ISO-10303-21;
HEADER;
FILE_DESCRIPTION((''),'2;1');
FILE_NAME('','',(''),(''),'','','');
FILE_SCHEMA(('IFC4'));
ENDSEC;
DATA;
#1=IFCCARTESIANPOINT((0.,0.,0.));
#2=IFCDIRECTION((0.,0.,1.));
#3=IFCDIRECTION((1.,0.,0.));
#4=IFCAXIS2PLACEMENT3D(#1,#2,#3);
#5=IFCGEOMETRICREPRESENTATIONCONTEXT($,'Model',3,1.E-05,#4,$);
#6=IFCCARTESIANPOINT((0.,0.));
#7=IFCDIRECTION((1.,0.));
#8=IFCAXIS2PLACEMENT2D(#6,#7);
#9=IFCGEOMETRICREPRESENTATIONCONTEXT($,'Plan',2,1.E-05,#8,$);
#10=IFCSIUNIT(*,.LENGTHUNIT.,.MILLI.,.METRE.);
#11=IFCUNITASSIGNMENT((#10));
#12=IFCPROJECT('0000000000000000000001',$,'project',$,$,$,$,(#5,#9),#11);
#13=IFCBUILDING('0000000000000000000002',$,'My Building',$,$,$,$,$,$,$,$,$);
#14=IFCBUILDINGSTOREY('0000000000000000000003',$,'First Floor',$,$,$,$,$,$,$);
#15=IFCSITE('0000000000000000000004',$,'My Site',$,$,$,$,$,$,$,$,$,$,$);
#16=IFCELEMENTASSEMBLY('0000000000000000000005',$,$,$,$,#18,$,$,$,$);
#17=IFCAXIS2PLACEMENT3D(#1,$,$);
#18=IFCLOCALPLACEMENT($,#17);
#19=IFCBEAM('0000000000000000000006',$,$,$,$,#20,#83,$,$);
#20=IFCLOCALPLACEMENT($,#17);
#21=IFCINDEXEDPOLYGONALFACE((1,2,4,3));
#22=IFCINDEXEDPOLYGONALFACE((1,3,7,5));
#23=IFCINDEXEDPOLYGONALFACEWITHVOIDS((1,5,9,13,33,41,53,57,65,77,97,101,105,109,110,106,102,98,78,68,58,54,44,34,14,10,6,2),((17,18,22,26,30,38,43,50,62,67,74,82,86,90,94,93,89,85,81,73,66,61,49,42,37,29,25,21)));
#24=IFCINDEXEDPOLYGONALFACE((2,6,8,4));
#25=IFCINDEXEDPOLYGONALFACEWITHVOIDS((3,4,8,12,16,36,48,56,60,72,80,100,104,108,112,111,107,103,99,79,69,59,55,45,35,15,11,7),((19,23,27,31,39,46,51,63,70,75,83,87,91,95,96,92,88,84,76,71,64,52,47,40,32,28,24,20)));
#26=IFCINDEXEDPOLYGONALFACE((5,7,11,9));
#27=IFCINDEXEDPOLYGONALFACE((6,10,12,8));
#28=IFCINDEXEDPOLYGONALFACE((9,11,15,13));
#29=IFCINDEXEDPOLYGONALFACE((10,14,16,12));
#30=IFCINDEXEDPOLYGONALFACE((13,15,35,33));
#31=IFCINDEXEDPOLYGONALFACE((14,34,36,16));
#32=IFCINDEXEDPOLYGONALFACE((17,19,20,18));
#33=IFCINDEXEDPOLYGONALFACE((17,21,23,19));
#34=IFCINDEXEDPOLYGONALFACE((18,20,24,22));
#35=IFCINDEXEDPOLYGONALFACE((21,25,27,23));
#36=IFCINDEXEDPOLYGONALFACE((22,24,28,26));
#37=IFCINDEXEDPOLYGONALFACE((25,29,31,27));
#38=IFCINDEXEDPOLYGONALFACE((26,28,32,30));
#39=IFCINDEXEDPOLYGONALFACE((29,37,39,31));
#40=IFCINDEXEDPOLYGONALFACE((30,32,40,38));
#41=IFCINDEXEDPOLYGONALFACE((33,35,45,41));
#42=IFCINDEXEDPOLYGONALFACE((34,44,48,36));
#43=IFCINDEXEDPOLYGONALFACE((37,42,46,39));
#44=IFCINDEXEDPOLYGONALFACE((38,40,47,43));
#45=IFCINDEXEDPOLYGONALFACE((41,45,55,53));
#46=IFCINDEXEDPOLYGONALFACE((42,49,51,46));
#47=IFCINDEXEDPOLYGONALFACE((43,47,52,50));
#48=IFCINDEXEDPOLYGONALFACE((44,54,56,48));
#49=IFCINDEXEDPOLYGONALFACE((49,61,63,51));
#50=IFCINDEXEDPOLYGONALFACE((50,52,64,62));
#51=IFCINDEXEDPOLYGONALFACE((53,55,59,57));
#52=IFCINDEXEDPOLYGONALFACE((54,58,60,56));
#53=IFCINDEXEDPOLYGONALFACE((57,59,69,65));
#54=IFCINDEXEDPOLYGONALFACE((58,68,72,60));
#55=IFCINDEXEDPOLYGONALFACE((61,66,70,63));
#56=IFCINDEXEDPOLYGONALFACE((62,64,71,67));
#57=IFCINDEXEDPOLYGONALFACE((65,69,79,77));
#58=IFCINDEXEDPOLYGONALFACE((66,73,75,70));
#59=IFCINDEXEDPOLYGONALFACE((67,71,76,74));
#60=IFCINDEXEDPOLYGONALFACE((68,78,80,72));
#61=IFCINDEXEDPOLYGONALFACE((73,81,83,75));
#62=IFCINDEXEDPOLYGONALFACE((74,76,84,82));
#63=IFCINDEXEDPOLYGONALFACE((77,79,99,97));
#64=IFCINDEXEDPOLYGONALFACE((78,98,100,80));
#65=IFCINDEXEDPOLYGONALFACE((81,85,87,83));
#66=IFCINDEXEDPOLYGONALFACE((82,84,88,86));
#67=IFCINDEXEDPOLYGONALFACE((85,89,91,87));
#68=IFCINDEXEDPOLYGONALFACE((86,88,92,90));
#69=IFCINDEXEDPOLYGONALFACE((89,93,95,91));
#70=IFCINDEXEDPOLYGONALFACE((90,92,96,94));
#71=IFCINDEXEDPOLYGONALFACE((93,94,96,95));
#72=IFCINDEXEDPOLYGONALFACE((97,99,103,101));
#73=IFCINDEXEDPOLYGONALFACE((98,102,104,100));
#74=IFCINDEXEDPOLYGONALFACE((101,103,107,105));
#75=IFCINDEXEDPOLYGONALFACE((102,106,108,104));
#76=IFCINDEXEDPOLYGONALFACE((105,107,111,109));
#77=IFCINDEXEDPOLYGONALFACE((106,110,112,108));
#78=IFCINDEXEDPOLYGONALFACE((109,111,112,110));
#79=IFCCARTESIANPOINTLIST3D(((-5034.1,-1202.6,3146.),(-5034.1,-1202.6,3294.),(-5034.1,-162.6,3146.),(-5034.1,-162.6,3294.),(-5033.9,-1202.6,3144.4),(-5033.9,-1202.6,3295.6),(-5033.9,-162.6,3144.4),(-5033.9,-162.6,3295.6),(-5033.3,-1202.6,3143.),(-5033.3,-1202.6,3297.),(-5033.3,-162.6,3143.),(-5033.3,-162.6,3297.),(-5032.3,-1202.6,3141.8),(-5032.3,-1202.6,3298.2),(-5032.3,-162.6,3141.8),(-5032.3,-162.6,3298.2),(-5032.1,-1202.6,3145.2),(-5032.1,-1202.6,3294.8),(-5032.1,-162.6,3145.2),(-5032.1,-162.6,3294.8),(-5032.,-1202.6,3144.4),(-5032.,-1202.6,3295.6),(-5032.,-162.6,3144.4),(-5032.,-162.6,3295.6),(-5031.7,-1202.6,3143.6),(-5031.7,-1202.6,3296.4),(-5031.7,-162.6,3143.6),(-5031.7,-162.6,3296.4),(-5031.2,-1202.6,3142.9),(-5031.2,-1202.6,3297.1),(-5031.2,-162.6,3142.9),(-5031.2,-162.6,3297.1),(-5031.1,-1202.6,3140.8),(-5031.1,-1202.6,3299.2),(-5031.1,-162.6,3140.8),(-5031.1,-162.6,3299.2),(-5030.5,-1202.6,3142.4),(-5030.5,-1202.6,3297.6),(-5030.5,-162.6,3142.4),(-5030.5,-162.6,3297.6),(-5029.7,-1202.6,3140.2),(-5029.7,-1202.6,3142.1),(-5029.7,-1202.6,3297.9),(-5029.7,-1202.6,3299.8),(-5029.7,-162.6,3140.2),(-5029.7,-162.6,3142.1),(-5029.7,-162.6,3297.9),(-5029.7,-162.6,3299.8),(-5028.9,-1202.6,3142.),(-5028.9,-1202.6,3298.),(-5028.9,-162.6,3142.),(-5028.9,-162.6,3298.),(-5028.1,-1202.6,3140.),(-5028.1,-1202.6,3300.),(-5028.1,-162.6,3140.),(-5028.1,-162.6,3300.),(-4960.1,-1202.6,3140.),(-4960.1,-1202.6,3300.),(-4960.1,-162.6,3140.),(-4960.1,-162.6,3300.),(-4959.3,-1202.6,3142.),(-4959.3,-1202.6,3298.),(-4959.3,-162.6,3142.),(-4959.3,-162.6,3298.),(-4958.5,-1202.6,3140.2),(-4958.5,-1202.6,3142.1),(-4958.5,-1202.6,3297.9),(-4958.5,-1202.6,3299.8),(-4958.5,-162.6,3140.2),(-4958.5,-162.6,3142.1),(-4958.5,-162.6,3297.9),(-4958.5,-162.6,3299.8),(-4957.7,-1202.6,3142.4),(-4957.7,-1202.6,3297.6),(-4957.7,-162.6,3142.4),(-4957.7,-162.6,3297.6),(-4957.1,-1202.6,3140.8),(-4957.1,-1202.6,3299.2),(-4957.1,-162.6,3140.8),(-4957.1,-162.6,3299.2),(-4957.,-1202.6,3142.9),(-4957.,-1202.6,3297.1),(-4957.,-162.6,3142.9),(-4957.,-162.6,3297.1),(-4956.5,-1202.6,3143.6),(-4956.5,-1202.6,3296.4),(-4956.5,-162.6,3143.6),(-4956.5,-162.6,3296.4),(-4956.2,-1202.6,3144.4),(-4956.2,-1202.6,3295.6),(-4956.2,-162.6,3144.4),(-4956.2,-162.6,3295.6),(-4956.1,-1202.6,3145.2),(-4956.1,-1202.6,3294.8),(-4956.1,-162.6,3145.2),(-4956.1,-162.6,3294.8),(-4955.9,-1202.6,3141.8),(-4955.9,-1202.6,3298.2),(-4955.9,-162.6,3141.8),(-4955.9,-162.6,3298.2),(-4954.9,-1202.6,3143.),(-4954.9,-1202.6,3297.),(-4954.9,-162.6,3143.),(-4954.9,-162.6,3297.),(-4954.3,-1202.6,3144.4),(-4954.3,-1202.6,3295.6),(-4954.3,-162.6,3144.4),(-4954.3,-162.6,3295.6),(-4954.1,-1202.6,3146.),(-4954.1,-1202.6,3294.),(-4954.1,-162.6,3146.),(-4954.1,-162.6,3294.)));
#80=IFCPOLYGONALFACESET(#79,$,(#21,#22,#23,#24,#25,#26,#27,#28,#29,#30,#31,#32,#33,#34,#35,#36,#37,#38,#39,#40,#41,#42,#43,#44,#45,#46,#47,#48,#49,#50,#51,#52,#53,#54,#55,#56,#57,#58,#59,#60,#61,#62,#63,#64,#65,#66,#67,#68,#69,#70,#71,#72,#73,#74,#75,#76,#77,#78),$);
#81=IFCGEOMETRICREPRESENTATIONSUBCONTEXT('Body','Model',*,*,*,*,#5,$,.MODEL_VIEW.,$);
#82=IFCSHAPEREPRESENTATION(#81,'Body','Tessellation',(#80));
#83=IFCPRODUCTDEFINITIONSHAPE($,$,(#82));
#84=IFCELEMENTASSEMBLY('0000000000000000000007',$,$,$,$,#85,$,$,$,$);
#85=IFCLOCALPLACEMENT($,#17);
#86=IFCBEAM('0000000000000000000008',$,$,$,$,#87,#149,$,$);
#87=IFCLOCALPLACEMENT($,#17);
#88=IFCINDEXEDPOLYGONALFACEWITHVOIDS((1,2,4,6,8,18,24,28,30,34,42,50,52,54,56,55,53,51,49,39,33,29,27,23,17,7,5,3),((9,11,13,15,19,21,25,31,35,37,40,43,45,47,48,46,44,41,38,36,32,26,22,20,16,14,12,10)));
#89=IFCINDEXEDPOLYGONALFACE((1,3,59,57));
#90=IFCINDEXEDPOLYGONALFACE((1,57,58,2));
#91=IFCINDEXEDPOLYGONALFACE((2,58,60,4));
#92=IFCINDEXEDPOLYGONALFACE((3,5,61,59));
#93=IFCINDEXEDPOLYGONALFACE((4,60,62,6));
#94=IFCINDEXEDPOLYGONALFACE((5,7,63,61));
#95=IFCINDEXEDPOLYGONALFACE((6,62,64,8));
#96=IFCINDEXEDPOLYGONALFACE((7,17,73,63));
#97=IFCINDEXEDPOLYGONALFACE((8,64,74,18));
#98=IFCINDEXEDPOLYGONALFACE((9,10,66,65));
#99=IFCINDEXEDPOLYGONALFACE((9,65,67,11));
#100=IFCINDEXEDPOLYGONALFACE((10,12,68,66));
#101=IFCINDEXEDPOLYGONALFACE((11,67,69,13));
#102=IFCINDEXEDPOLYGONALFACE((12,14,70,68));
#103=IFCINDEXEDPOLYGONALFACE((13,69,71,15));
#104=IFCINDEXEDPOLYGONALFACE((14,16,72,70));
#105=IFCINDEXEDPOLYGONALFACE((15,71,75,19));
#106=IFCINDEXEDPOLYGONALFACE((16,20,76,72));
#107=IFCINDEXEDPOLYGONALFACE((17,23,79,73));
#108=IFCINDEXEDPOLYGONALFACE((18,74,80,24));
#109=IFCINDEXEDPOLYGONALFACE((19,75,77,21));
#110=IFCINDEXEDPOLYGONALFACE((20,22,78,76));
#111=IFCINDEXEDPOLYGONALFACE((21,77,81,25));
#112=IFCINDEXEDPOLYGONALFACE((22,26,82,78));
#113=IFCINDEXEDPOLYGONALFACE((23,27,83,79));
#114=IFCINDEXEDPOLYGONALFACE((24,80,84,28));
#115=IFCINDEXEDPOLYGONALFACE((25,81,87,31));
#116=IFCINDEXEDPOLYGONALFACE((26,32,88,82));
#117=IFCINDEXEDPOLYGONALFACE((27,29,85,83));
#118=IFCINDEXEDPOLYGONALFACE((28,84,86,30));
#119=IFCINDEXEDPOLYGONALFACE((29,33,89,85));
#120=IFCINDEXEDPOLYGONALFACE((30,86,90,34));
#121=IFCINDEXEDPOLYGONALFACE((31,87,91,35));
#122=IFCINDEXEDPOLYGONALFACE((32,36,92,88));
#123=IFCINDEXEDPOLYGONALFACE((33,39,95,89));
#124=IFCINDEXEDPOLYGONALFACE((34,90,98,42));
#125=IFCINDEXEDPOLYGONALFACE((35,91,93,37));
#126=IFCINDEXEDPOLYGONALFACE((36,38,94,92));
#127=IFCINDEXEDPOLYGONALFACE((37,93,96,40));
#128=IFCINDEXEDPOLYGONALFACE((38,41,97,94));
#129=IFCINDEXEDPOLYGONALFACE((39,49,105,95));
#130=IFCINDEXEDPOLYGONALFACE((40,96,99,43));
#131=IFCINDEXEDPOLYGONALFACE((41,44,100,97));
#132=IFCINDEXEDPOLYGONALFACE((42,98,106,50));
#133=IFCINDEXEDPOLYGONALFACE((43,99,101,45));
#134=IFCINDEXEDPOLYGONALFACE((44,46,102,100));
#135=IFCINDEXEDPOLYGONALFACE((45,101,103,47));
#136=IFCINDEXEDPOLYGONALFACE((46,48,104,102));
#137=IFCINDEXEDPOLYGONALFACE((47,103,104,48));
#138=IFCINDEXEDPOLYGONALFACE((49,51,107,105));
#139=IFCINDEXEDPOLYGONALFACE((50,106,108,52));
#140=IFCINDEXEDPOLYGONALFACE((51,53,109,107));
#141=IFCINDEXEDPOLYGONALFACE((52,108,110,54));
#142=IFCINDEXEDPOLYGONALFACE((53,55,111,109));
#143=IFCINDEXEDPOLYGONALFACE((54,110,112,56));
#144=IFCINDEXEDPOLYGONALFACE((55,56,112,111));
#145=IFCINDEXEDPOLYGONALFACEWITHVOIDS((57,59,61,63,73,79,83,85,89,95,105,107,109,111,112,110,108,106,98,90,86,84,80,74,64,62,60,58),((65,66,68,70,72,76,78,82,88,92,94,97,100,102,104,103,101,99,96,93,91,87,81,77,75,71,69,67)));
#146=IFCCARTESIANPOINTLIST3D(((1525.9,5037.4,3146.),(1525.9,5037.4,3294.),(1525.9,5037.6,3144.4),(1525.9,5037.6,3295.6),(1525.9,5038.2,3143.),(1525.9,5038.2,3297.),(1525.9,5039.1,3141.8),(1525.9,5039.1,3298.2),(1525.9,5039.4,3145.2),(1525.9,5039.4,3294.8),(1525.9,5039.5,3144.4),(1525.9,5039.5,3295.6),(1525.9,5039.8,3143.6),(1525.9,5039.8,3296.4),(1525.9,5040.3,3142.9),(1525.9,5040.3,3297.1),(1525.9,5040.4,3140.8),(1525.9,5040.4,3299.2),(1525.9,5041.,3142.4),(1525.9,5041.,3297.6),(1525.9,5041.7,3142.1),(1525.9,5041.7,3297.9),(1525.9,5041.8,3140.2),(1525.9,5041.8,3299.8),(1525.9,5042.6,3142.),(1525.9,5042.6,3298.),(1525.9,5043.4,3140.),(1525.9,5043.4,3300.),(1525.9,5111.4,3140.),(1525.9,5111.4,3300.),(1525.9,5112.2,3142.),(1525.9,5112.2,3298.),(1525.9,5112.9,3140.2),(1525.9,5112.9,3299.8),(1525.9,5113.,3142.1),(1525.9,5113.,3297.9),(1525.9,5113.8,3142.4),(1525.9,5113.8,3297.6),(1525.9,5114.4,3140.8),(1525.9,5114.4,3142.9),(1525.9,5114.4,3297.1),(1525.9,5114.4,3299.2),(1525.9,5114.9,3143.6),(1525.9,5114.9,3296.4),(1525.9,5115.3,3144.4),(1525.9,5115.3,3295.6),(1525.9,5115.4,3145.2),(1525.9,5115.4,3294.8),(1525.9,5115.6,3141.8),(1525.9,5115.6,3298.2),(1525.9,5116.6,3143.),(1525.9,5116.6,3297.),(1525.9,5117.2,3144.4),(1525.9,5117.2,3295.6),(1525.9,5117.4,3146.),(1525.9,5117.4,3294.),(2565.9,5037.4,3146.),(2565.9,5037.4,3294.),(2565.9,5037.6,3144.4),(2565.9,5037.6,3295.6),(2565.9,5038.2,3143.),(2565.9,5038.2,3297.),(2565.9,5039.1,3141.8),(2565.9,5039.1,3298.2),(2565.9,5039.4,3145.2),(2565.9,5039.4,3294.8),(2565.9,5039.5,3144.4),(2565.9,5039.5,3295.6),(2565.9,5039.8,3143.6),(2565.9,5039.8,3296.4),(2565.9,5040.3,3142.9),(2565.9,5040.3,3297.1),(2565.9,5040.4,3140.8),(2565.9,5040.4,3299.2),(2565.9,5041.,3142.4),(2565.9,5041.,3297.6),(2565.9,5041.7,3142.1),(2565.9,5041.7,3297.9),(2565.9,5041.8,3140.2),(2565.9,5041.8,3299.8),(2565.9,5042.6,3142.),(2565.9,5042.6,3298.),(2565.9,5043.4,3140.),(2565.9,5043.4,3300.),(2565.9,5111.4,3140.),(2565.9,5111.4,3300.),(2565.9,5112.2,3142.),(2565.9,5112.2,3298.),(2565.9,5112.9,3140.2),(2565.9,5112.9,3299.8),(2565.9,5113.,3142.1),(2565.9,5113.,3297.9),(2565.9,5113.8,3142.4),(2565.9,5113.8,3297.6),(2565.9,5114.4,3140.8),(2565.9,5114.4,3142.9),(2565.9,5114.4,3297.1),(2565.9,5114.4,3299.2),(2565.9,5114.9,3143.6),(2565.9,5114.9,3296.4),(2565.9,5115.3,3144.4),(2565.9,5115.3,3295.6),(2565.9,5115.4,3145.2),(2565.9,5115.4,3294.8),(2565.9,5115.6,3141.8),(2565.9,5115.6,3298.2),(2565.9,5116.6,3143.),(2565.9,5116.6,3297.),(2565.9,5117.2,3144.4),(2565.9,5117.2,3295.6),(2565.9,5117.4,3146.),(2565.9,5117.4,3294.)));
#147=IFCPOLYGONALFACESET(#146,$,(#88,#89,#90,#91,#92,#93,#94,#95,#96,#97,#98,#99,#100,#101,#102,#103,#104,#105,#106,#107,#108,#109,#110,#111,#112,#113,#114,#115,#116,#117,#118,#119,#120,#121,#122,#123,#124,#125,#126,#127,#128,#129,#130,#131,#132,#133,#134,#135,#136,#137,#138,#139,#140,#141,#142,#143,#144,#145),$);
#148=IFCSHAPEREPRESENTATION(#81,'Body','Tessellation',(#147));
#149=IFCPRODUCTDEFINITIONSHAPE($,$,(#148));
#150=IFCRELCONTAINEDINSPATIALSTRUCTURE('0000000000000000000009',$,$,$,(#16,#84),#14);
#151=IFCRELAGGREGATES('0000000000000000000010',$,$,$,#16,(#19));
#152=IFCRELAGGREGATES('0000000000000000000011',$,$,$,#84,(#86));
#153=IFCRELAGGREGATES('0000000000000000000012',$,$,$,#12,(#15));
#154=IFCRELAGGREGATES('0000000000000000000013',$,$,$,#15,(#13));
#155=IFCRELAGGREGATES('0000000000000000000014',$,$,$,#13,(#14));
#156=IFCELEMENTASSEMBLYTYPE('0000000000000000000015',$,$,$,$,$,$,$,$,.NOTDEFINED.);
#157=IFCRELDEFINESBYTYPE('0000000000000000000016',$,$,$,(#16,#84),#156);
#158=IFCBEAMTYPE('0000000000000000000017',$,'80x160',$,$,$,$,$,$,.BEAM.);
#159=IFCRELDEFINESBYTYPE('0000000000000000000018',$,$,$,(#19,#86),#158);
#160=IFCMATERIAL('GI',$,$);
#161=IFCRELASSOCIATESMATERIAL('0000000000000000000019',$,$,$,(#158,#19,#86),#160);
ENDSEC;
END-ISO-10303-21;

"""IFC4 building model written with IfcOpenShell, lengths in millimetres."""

from ifc_helpers import new_model, si_unit, frame, origin_with_axes, origin_2d_with_axis, place, context, subcontext, project, spatial, hollow_rectangle, extrude, material, material_profile, profile_set, profile_usage, type_object, element, aggregate, save


model = new_model("IFC4")

# Units and contexts
model_context = context("Model", 3, precision=1e-05, world=origin_with_axes())
plan_context = context("Plan", 2, precision=1e-05, world=origin_2d_with_axis())
body_context = subcontext(model_context, "Body", "Model", "MODEL_VIEW")
ifc_project = project(units=[si_unit("LENGTHUNIT", "METRE", prefix="MILLI")], contexts=[model_context, plan_context])

# Site, building, storey
site = spatial("IfcSite", under=ifc_project, Name="My Site")
building = spatial("IfcBuilding", under=site, Name="My Building")
storey = spatial("IfcBuildingStorey", under=building, Name="First Floor")

# Element assemblies, beams
element_assembly_type = type_object("IfcElementAssemblyType", PredefinedType="NOTDEFINED")
ifc_material = material(Name="GI")
ifc_material_profile = material_profile(ifc_material, hollow_rectangle(XDim=80.0, YDim=160.0, WallThickness=2.0, InnerFilletRadius=3.2, OuterFilletRadius=6.0))
ifc_profile_set = profile_set([ifc_material_profile], Name="80x160 GI Rectangular Hollow")
beam_type = type_object("IfcBeamType", Name="80x160", PredefinedType="BEAM", material=ifc_profile_set)
assembly_1_placement = place(None, frame((-4994.1, -1282.6, 3220.0), z_axis=(0.0, 1.0, 0.0), x_axis=(1.0, 0.0, 0.0)))
assembly_1 = element("IfcElementAssembly", 1, at=assembly_1_placement, inside=storey, type_object=element_assembly_type)
ifc_profile_usage_1 = profile_usage(ifc_profile_set)
beam_1_placement = place(assembly_1_placement, frame((0.0, 0.0, 80.0), z_axis=(0.0, 0.0, 1.0), x_axis=(1.0, 0.0, 0.0)))
beam_1 = element("IfcBeam", 2, at=beam_1_placement, type_object=beam_type, material=ifc_profile_usage_1, context=body_context, shape_type="SweptSolid", body=[
    extrude(hollow_rectangle(XDim=80.0, YDim=160.0, WallThickness=2.0, InnerFilletRadius=3.2, OuterFilletRadius=6.0), origin_with_axes(), (0.0, 0.0, 1.0), 1040.0),
])
aggregate(assembly_1, [beam_1])
assembly_2_placement = place(None, frame((1445.9, 5077.4, 3220.0), z_axis=(1.0, 0.0, 0.0), x_axis=(0.0, 1.0, 0.0)))
assembly_2 = element("IfcElementAssembly", 3, at=assembly_2_placement, inside=storey, type_object=element_assembly_type)
ifc_profile_usage_2 = profile_usage(ifc_profile_set)
beam_2_placement = place(assembly_2_placement, frame((0.0, 0.0, 80.0), z_axis=(0.0, 0.0, 1.0), x_axis=(1.0, 0.0, 0.0)))
beam_2 = element("IfcBeam", 4, at=beam_2_placement, type_object=beam_type, material=ifc_profile_usage_2, context=body_context, shape_type="SweptSolid", body=[
    extrude(hollow_rectangle(XDim=80.0, YDim=160.0, WallThickness=2.0, InnerFilletRadius=3.2, OuterFilletRadius=6.0), origin_with_axes(), (0.0, 0.0, 1.0), 1040.0),
])
aggregate(assembly_2, [beam_2])

save(model, "model.ifc")
